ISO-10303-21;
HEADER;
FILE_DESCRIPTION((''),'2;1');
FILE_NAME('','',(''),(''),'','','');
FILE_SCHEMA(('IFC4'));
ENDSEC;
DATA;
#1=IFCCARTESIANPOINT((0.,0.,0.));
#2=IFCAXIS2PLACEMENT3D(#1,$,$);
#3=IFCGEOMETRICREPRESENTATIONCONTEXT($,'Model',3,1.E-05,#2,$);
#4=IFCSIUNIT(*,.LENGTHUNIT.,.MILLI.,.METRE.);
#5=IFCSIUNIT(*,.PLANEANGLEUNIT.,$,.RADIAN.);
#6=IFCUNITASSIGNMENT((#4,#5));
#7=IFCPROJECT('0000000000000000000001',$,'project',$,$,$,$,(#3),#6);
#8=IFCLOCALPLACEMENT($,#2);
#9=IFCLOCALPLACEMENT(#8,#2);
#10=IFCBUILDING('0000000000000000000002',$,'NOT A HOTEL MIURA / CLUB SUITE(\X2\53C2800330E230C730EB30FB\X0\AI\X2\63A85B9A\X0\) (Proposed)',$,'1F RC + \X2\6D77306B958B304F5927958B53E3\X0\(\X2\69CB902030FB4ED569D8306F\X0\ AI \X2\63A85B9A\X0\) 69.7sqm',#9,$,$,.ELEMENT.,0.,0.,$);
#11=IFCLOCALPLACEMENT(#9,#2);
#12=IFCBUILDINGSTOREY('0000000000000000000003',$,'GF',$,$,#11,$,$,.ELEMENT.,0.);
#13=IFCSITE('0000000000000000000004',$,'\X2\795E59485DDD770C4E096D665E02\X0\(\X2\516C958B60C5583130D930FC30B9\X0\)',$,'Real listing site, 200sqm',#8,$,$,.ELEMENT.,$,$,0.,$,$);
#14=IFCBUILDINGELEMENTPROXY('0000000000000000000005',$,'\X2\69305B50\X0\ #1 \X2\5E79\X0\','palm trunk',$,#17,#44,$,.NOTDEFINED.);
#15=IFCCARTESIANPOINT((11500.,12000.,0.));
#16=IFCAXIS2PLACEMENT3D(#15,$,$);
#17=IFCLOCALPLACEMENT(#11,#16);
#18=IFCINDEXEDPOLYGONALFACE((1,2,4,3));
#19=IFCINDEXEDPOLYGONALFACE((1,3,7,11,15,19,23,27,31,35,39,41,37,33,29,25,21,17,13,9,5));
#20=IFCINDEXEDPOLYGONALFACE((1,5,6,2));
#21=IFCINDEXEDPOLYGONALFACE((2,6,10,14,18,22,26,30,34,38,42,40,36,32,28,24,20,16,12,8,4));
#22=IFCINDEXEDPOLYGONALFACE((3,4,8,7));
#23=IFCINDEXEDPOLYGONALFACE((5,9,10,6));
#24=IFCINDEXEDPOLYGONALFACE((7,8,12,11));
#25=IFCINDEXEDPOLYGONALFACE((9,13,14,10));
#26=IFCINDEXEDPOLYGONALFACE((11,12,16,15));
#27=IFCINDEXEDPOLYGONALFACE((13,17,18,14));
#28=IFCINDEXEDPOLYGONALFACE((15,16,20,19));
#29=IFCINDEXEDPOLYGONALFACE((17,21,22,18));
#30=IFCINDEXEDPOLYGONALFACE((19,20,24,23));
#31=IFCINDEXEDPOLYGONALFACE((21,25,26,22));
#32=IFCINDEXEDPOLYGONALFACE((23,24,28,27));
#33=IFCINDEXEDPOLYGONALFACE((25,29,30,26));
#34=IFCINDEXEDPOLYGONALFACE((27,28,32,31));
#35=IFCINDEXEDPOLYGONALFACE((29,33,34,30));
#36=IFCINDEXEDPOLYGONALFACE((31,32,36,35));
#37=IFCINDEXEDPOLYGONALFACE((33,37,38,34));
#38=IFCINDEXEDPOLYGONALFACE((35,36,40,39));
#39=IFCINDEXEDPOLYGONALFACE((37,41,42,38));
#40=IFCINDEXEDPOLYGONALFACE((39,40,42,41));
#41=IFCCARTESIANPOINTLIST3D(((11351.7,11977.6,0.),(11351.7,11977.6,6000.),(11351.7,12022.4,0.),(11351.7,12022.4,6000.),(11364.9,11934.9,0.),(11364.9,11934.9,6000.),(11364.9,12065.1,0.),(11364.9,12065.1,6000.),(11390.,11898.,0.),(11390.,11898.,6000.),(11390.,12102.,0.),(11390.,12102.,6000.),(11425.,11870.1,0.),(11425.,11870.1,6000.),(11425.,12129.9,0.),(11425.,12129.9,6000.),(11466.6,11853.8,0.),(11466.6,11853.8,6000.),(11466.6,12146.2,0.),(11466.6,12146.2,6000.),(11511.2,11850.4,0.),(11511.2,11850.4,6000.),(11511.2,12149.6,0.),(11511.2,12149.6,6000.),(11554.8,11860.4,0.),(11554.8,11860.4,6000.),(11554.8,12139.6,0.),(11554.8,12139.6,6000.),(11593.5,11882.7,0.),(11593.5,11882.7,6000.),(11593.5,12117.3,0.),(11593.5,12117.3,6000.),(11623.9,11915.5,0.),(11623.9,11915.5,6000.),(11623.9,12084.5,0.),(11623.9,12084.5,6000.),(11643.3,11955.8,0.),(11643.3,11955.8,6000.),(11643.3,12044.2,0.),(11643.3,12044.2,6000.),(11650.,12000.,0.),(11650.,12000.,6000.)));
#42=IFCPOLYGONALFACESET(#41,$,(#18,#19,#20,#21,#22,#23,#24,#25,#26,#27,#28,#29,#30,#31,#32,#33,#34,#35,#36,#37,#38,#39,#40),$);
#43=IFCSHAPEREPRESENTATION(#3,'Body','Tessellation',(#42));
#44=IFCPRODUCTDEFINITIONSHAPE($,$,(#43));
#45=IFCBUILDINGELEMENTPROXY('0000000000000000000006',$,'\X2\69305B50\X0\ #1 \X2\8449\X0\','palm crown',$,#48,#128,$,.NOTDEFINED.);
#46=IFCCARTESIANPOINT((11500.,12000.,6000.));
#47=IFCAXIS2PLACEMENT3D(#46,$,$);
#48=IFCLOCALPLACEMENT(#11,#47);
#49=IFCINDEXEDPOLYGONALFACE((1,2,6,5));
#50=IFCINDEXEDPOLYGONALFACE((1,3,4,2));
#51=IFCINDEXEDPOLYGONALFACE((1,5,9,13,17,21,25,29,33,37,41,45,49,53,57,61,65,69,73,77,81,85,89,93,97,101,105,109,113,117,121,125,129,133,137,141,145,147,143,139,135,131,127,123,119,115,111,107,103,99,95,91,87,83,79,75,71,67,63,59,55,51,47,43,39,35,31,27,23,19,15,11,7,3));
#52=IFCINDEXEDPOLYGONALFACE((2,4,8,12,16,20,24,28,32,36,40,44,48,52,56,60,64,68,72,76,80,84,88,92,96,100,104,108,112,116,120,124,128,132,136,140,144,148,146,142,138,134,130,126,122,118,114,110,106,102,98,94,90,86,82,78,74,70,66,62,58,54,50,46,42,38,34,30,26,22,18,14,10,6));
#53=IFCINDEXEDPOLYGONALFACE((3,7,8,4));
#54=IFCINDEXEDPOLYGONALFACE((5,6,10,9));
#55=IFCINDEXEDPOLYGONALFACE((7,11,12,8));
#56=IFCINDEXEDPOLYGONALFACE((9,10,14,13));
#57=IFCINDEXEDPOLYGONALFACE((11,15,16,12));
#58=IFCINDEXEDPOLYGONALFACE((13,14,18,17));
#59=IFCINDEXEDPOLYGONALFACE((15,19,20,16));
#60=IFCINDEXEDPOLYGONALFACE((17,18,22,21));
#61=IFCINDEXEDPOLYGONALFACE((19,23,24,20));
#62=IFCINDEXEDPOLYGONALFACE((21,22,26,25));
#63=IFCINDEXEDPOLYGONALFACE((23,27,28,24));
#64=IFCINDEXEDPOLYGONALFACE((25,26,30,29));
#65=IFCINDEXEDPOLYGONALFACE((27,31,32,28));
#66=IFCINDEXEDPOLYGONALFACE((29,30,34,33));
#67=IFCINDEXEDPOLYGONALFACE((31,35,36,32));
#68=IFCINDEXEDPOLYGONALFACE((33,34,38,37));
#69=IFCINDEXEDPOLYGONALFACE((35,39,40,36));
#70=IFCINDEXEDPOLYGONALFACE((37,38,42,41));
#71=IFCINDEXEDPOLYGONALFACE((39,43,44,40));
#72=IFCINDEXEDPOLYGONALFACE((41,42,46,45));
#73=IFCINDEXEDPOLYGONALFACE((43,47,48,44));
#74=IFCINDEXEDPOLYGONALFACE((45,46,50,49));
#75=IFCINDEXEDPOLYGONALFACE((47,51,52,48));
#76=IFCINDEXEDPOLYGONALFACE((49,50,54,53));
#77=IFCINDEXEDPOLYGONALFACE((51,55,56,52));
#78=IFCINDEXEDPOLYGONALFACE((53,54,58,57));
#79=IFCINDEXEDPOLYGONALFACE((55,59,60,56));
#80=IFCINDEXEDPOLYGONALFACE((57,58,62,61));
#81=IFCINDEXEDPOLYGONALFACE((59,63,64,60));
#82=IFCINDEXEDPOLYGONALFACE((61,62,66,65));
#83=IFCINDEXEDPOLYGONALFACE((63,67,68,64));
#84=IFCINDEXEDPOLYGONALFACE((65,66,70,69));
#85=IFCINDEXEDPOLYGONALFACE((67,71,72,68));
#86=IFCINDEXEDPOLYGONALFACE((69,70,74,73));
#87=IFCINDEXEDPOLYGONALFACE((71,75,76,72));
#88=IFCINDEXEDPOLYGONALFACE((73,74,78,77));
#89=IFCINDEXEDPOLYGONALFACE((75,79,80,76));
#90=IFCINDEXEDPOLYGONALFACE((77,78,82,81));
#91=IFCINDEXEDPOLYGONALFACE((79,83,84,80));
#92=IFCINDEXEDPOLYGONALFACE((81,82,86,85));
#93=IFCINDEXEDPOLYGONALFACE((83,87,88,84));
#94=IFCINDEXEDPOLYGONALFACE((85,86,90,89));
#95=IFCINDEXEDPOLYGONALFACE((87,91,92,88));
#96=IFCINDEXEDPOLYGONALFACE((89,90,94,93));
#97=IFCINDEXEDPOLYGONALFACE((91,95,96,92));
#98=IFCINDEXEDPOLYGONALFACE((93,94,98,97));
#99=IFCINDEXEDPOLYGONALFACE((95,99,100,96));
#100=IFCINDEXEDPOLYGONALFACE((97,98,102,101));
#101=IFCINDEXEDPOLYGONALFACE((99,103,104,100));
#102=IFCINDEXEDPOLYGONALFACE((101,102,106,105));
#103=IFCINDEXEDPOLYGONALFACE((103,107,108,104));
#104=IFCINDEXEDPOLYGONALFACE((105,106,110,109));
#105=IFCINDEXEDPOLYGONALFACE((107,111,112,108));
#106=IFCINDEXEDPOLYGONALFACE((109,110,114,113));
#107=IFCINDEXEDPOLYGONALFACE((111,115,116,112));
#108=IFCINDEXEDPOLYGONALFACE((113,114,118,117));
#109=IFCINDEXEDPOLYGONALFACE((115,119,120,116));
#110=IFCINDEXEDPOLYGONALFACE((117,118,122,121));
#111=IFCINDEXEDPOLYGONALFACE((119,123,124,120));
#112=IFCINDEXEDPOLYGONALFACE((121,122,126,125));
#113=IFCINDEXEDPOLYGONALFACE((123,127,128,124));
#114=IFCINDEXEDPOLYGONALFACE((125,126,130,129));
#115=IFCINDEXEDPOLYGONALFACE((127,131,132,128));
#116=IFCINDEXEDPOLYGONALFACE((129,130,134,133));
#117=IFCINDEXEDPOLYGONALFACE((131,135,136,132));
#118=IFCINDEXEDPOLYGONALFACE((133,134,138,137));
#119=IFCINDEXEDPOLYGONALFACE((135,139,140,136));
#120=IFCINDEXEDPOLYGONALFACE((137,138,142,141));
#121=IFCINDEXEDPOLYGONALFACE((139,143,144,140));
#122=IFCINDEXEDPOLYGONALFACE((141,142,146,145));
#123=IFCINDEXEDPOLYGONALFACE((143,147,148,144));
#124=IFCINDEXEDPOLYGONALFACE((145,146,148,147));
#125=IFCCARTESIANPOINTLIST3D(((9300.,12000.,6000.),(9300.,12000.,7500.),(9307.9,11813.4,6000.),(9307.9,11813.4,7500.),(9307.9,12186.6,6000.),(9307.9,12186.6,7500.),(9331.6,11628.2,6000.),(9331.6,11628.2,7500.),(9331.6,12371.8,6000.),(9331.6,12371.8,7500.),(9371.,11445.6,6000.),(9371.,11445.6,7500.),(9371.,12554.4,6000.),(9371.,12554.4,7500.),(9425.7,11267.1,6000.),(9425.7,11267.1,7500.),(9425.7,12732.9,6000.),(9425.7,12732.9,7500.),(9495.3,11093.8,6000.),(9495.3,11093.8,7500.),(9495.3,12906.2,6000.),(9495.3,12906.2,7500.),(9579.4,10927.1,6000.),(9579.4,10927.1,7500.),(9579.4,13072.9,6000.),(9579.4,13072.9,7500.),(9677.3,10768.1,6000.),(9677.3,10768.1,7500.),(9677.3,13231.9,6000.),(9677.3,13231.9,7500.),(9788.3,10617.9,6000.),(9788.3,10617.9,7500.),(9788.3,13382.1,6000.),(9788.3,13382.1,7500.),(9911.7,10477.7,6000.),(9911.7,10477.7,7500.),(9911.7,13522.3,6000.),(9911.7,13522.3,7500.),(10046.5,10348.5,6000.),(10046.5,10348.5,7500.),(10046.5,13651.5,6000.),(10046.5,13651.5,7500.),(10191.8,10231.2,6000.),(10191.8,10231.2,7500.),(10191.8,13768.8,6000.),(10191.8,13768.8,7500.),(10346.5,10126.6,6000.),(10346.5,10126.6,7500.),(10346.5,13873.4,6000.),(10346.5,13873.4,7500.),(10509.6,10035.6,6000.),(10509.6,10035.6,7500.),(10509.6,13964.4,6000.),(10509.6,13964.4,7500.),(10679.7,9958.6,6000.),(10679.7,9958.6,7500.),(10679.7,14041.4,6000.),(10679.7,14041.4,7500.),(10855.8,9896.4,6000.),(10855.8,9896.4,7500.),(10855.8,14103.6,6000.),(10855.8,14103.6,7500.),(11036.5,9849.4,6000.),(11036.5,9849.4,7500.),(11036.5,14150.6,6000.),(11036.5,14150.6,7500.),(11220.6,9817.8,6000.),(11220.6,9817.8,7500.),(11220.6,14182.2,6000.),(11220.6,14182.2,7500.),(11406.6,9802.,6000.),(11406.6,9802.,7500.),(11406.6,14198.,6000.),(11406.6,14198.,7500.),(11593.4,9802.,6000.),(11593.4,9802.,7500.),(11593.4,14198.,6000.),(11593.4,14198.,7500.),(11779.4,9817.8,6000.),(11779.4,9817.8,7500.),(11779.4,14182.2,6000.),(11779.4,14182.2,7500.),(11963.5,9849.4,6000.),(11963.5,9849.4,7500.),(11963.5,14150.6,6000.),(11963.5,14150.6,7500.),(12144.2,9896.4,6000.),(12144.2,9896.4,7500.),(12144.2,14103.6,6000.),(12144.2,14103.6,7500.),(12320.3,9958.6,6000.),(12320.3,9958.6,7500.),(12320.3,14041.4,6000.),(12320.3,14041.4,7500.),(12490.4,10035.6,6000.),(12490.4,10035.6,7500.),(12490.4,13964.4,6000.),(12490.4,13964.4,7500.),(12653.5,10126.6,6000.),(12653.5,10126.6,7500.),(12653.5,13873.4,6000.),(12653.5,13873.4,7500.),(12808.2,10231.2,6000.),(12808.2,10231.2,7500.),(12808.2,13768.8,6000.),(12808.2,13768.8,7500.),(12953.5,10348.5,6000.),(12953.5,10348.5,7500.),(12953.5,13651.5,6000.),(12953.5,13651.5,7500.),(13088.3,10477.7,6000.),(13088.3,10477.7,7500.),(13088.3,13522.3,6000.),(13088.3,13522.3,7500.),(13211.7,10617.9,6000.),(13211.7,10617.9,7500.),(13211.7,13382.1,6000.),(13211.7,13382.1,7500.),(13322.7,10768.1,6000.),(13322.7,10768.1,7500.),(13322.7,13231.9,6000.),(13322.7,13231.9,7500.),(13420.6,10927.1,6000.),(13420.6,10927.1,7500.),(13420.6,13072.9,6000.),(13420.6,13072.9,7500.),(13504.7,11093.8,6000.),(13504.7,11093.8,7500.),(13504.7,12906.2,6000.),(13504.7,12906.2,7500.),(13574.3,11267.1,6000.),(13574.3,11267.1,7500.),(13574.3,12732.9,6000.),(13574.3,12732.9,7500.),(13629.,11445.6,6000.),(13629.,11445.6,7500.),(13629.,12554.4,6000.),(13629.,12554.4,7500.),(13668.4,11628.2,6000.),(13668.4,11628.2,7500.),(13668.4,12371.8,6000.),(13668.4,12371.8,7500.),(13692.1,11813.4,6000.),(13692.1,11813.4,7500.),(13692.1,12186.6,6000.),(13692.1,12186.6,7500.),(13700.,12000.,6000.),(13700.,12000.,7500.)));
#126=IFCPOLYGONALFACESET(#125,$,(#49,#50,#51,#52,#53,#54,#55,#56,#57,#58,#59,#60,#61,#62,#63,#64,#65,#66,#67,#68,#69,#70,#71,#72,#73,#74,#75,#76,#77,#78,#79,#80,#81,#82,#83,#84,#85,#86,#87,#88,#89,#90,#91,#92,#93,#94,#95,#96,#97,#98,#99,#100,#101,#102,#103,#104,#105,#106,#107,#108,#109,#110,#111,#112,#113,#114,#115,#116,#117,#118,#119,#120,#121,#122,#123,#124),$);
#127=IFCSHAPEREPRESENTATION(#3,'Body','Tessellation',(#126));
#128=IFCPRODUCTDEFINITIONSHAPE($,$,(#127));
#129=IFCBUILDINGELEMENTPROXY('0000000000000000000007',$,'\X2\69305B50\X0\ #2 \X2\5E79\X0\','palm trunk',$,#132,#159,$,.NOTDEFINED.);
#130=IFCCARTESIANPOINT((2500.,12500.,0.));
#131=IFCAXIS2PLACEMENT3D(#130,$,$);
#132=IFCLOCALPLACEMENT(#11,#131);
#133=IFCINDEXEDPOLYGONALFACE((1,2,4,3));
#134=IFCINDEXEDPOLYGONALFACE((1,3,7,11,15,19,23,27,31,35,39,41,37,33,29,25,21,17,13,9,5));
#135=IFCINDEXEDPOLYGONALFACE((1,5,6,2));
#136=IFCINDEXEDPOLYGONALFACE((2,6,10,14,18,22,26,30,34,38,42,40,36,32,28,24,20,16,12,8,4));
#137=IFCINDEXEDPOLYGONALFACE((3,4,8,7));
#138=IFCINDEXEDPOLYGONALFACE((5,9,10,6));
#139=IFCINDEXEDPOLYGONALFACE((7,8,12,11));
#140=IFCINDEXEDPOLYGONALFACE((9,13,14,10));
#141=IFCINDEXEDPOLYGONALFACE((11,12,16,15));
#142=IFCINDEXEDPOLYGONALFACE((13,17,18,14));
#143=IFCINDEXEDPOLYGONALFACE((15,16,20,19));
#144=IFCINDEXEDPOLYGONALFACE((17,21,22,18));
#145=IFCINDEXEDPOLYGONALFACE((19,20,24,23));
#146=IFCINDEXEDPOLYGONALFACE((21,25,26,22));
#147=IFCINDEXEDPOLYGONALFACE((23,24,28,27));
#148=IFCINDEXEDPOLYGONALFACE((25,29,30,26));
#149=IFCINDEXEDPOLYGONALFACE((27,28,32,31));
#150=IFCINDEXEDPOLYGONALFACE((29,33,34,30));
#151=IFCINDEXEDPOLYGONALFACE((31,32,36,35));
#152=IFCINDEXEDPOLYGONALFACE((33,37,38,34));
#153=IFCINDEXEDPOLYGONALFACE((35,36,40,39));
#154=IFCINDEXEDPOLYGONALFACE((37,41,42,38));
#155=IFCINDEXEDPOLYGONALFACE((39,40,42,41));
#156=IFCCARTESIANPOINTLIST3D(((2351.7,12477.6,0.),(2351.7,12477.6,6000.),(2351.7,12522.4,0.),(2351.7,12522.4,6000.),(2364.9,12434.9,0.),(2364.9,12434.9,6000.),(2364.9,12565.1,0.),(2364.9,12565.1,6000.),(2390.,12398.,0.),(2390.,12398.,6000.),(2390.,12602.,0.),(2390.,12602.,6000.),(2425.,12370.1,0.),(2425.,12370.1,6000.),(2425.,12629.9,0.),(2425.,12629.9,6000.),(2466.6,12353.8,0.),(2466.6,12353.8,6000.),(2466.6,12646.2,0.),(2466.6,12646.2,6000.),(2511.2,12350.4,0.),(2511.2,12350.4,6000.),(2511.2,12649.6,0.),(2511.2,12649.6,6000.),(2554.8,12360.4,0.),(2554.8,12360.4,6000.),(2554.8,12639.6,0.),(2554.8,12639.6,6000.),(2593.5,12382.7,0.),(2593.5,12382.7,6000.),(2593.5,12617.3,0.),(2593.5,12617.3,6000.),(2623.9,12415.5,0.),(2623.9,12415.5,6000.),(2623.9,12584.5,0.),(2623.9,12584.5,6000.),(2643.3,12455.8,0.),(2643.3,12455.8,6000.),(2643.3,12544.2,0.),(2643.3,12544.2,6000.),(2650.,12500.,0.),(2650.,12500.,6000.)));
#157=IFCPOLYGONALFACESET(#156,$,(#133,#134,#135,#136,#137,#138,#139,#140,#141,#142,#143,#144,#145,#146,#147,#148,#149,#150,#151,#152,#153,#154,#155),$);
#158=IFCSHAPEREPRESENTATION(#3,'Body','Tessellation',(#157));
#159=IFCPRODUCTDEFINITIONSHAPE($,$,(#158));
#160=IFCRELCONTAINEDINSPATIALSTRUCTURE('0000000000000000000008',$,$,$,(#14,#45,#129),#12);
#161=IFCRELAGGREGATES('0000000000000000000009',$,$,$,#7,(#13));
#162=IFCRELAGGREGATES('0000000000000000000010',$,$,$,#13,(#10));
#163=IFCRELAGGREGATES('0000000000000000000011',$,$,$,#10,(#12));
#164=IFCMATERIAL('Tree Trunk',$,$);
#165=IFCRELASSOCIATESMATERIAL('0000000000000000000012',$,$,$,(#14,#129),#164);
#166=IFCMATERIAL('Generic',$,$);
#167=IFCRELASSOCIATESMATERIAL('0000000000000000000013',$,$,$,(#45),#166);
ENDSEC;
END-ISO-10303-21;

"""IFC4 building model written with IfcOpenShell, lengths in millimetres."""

from ifc_helpers import new_model, si_unit, frame, origin, origin_2d, place, context, project, spatial, circle, extrude, material, element, save


model = new_model("IFC4")

# Units and contexts
model_context = context("Model", 3, precision=1e-05, world=origin())
ifc_project = project(units=[si_unit("LENGTHUNIT", "METRE", prefix="MILLI"), si_unit("PLANEANGLEUNIT", "RADIAN")], contexts=[model_context])

# Site, building, storey
site_placement = place(None, origin())
site = spatial("IfcSite", under=ifc_project, at=site_placement, Name="神奈川県三浦市(公開情報ベース)", ObjectType="Real listing site, 200sqm", CompositionType="ELEMENT", RefElevation=0.0)
building_placement = place(site_placement, origin())
building = spatial("IfcBuilding", under=site, at=building_placement, Name="NOT A HOTEL MIURA / CLUB SUITE(参考モデル・AI推定) (Proposed)", ObjectType="1F RC + 海に開く大開口(構造・仕様は AI 推定) 69.7sqm", CompositionType="ELEMENT", ElevationOfRefHeight=0.0, ElevationOfTerrain=0.0)
storey_placement = place(building_placement, origin())
storey = spatial("IfcBuildingStorey", under=building, at=storey_placement, Name="GF", CompositionType="ELEMENT", Elevation=0.0)

# Shared definitions
ifc_material_1 = material(Name="Generic")

# Building element proxies
ifc_material_2 = material(Name="Tree Trunk")
proxy_1_placement = place(storey_placement, frame((11500.0, 12000.0, 0.0)))
element("IfcBuildingElementProxy", 1, at=proxy_1_placement, inside=storey, material=ifc_material_2, Name="椰子 #1 幹", Description="palm trunk", PredefinedType="NOTDEFINED", context=model_context, shape_type="SweptSolid", body=[
    extrude(circle(Radius=150.0, at=origin_2d()), frame((11500.0, 12000.0, 0.0)), (0.0, 0.0, 1.0), 6000.0),
])
proxy_2_placement = place(storey_placement, frame((11500.0, 12000.0, 6000.0)))
element("IfcBuildingElementProxy", 2, at=proxy_2_placement, inside=storey, material=ifc_material_1, Name="椰子 #1 葉", Description="palm crown", PredefinedType="NOTDEFINED", context=model_context, shape_type="SweptSolid", body=[
    extrude(circle(Radius=2200.0, at=origin_2d()), frame((11500.0, 12000.0, 6000.0)), (0.0, 0.0, 1.0), 1500.0),
])
proxy_3_placement = place(storey_placement, frame((2500.0, 12500.0, 0.0)))
element("IfcBuildingElementProxy", 3, at=proxy_3_placement, inside=storey, material=ifc_material_2, Name="椰子 #2 幹", Description="palm trunk", PredefinedType="NOTDEFINED", context=model_context, shape_type="SweptSolid", body=[
    extrude(circle(Radius=150.0, at=origin_2d()), frame((2500.0, 12500.0, 0.0)), (0.0, 0.0, 1.0), 6000.0),
])

save(model, "model.ifc")
